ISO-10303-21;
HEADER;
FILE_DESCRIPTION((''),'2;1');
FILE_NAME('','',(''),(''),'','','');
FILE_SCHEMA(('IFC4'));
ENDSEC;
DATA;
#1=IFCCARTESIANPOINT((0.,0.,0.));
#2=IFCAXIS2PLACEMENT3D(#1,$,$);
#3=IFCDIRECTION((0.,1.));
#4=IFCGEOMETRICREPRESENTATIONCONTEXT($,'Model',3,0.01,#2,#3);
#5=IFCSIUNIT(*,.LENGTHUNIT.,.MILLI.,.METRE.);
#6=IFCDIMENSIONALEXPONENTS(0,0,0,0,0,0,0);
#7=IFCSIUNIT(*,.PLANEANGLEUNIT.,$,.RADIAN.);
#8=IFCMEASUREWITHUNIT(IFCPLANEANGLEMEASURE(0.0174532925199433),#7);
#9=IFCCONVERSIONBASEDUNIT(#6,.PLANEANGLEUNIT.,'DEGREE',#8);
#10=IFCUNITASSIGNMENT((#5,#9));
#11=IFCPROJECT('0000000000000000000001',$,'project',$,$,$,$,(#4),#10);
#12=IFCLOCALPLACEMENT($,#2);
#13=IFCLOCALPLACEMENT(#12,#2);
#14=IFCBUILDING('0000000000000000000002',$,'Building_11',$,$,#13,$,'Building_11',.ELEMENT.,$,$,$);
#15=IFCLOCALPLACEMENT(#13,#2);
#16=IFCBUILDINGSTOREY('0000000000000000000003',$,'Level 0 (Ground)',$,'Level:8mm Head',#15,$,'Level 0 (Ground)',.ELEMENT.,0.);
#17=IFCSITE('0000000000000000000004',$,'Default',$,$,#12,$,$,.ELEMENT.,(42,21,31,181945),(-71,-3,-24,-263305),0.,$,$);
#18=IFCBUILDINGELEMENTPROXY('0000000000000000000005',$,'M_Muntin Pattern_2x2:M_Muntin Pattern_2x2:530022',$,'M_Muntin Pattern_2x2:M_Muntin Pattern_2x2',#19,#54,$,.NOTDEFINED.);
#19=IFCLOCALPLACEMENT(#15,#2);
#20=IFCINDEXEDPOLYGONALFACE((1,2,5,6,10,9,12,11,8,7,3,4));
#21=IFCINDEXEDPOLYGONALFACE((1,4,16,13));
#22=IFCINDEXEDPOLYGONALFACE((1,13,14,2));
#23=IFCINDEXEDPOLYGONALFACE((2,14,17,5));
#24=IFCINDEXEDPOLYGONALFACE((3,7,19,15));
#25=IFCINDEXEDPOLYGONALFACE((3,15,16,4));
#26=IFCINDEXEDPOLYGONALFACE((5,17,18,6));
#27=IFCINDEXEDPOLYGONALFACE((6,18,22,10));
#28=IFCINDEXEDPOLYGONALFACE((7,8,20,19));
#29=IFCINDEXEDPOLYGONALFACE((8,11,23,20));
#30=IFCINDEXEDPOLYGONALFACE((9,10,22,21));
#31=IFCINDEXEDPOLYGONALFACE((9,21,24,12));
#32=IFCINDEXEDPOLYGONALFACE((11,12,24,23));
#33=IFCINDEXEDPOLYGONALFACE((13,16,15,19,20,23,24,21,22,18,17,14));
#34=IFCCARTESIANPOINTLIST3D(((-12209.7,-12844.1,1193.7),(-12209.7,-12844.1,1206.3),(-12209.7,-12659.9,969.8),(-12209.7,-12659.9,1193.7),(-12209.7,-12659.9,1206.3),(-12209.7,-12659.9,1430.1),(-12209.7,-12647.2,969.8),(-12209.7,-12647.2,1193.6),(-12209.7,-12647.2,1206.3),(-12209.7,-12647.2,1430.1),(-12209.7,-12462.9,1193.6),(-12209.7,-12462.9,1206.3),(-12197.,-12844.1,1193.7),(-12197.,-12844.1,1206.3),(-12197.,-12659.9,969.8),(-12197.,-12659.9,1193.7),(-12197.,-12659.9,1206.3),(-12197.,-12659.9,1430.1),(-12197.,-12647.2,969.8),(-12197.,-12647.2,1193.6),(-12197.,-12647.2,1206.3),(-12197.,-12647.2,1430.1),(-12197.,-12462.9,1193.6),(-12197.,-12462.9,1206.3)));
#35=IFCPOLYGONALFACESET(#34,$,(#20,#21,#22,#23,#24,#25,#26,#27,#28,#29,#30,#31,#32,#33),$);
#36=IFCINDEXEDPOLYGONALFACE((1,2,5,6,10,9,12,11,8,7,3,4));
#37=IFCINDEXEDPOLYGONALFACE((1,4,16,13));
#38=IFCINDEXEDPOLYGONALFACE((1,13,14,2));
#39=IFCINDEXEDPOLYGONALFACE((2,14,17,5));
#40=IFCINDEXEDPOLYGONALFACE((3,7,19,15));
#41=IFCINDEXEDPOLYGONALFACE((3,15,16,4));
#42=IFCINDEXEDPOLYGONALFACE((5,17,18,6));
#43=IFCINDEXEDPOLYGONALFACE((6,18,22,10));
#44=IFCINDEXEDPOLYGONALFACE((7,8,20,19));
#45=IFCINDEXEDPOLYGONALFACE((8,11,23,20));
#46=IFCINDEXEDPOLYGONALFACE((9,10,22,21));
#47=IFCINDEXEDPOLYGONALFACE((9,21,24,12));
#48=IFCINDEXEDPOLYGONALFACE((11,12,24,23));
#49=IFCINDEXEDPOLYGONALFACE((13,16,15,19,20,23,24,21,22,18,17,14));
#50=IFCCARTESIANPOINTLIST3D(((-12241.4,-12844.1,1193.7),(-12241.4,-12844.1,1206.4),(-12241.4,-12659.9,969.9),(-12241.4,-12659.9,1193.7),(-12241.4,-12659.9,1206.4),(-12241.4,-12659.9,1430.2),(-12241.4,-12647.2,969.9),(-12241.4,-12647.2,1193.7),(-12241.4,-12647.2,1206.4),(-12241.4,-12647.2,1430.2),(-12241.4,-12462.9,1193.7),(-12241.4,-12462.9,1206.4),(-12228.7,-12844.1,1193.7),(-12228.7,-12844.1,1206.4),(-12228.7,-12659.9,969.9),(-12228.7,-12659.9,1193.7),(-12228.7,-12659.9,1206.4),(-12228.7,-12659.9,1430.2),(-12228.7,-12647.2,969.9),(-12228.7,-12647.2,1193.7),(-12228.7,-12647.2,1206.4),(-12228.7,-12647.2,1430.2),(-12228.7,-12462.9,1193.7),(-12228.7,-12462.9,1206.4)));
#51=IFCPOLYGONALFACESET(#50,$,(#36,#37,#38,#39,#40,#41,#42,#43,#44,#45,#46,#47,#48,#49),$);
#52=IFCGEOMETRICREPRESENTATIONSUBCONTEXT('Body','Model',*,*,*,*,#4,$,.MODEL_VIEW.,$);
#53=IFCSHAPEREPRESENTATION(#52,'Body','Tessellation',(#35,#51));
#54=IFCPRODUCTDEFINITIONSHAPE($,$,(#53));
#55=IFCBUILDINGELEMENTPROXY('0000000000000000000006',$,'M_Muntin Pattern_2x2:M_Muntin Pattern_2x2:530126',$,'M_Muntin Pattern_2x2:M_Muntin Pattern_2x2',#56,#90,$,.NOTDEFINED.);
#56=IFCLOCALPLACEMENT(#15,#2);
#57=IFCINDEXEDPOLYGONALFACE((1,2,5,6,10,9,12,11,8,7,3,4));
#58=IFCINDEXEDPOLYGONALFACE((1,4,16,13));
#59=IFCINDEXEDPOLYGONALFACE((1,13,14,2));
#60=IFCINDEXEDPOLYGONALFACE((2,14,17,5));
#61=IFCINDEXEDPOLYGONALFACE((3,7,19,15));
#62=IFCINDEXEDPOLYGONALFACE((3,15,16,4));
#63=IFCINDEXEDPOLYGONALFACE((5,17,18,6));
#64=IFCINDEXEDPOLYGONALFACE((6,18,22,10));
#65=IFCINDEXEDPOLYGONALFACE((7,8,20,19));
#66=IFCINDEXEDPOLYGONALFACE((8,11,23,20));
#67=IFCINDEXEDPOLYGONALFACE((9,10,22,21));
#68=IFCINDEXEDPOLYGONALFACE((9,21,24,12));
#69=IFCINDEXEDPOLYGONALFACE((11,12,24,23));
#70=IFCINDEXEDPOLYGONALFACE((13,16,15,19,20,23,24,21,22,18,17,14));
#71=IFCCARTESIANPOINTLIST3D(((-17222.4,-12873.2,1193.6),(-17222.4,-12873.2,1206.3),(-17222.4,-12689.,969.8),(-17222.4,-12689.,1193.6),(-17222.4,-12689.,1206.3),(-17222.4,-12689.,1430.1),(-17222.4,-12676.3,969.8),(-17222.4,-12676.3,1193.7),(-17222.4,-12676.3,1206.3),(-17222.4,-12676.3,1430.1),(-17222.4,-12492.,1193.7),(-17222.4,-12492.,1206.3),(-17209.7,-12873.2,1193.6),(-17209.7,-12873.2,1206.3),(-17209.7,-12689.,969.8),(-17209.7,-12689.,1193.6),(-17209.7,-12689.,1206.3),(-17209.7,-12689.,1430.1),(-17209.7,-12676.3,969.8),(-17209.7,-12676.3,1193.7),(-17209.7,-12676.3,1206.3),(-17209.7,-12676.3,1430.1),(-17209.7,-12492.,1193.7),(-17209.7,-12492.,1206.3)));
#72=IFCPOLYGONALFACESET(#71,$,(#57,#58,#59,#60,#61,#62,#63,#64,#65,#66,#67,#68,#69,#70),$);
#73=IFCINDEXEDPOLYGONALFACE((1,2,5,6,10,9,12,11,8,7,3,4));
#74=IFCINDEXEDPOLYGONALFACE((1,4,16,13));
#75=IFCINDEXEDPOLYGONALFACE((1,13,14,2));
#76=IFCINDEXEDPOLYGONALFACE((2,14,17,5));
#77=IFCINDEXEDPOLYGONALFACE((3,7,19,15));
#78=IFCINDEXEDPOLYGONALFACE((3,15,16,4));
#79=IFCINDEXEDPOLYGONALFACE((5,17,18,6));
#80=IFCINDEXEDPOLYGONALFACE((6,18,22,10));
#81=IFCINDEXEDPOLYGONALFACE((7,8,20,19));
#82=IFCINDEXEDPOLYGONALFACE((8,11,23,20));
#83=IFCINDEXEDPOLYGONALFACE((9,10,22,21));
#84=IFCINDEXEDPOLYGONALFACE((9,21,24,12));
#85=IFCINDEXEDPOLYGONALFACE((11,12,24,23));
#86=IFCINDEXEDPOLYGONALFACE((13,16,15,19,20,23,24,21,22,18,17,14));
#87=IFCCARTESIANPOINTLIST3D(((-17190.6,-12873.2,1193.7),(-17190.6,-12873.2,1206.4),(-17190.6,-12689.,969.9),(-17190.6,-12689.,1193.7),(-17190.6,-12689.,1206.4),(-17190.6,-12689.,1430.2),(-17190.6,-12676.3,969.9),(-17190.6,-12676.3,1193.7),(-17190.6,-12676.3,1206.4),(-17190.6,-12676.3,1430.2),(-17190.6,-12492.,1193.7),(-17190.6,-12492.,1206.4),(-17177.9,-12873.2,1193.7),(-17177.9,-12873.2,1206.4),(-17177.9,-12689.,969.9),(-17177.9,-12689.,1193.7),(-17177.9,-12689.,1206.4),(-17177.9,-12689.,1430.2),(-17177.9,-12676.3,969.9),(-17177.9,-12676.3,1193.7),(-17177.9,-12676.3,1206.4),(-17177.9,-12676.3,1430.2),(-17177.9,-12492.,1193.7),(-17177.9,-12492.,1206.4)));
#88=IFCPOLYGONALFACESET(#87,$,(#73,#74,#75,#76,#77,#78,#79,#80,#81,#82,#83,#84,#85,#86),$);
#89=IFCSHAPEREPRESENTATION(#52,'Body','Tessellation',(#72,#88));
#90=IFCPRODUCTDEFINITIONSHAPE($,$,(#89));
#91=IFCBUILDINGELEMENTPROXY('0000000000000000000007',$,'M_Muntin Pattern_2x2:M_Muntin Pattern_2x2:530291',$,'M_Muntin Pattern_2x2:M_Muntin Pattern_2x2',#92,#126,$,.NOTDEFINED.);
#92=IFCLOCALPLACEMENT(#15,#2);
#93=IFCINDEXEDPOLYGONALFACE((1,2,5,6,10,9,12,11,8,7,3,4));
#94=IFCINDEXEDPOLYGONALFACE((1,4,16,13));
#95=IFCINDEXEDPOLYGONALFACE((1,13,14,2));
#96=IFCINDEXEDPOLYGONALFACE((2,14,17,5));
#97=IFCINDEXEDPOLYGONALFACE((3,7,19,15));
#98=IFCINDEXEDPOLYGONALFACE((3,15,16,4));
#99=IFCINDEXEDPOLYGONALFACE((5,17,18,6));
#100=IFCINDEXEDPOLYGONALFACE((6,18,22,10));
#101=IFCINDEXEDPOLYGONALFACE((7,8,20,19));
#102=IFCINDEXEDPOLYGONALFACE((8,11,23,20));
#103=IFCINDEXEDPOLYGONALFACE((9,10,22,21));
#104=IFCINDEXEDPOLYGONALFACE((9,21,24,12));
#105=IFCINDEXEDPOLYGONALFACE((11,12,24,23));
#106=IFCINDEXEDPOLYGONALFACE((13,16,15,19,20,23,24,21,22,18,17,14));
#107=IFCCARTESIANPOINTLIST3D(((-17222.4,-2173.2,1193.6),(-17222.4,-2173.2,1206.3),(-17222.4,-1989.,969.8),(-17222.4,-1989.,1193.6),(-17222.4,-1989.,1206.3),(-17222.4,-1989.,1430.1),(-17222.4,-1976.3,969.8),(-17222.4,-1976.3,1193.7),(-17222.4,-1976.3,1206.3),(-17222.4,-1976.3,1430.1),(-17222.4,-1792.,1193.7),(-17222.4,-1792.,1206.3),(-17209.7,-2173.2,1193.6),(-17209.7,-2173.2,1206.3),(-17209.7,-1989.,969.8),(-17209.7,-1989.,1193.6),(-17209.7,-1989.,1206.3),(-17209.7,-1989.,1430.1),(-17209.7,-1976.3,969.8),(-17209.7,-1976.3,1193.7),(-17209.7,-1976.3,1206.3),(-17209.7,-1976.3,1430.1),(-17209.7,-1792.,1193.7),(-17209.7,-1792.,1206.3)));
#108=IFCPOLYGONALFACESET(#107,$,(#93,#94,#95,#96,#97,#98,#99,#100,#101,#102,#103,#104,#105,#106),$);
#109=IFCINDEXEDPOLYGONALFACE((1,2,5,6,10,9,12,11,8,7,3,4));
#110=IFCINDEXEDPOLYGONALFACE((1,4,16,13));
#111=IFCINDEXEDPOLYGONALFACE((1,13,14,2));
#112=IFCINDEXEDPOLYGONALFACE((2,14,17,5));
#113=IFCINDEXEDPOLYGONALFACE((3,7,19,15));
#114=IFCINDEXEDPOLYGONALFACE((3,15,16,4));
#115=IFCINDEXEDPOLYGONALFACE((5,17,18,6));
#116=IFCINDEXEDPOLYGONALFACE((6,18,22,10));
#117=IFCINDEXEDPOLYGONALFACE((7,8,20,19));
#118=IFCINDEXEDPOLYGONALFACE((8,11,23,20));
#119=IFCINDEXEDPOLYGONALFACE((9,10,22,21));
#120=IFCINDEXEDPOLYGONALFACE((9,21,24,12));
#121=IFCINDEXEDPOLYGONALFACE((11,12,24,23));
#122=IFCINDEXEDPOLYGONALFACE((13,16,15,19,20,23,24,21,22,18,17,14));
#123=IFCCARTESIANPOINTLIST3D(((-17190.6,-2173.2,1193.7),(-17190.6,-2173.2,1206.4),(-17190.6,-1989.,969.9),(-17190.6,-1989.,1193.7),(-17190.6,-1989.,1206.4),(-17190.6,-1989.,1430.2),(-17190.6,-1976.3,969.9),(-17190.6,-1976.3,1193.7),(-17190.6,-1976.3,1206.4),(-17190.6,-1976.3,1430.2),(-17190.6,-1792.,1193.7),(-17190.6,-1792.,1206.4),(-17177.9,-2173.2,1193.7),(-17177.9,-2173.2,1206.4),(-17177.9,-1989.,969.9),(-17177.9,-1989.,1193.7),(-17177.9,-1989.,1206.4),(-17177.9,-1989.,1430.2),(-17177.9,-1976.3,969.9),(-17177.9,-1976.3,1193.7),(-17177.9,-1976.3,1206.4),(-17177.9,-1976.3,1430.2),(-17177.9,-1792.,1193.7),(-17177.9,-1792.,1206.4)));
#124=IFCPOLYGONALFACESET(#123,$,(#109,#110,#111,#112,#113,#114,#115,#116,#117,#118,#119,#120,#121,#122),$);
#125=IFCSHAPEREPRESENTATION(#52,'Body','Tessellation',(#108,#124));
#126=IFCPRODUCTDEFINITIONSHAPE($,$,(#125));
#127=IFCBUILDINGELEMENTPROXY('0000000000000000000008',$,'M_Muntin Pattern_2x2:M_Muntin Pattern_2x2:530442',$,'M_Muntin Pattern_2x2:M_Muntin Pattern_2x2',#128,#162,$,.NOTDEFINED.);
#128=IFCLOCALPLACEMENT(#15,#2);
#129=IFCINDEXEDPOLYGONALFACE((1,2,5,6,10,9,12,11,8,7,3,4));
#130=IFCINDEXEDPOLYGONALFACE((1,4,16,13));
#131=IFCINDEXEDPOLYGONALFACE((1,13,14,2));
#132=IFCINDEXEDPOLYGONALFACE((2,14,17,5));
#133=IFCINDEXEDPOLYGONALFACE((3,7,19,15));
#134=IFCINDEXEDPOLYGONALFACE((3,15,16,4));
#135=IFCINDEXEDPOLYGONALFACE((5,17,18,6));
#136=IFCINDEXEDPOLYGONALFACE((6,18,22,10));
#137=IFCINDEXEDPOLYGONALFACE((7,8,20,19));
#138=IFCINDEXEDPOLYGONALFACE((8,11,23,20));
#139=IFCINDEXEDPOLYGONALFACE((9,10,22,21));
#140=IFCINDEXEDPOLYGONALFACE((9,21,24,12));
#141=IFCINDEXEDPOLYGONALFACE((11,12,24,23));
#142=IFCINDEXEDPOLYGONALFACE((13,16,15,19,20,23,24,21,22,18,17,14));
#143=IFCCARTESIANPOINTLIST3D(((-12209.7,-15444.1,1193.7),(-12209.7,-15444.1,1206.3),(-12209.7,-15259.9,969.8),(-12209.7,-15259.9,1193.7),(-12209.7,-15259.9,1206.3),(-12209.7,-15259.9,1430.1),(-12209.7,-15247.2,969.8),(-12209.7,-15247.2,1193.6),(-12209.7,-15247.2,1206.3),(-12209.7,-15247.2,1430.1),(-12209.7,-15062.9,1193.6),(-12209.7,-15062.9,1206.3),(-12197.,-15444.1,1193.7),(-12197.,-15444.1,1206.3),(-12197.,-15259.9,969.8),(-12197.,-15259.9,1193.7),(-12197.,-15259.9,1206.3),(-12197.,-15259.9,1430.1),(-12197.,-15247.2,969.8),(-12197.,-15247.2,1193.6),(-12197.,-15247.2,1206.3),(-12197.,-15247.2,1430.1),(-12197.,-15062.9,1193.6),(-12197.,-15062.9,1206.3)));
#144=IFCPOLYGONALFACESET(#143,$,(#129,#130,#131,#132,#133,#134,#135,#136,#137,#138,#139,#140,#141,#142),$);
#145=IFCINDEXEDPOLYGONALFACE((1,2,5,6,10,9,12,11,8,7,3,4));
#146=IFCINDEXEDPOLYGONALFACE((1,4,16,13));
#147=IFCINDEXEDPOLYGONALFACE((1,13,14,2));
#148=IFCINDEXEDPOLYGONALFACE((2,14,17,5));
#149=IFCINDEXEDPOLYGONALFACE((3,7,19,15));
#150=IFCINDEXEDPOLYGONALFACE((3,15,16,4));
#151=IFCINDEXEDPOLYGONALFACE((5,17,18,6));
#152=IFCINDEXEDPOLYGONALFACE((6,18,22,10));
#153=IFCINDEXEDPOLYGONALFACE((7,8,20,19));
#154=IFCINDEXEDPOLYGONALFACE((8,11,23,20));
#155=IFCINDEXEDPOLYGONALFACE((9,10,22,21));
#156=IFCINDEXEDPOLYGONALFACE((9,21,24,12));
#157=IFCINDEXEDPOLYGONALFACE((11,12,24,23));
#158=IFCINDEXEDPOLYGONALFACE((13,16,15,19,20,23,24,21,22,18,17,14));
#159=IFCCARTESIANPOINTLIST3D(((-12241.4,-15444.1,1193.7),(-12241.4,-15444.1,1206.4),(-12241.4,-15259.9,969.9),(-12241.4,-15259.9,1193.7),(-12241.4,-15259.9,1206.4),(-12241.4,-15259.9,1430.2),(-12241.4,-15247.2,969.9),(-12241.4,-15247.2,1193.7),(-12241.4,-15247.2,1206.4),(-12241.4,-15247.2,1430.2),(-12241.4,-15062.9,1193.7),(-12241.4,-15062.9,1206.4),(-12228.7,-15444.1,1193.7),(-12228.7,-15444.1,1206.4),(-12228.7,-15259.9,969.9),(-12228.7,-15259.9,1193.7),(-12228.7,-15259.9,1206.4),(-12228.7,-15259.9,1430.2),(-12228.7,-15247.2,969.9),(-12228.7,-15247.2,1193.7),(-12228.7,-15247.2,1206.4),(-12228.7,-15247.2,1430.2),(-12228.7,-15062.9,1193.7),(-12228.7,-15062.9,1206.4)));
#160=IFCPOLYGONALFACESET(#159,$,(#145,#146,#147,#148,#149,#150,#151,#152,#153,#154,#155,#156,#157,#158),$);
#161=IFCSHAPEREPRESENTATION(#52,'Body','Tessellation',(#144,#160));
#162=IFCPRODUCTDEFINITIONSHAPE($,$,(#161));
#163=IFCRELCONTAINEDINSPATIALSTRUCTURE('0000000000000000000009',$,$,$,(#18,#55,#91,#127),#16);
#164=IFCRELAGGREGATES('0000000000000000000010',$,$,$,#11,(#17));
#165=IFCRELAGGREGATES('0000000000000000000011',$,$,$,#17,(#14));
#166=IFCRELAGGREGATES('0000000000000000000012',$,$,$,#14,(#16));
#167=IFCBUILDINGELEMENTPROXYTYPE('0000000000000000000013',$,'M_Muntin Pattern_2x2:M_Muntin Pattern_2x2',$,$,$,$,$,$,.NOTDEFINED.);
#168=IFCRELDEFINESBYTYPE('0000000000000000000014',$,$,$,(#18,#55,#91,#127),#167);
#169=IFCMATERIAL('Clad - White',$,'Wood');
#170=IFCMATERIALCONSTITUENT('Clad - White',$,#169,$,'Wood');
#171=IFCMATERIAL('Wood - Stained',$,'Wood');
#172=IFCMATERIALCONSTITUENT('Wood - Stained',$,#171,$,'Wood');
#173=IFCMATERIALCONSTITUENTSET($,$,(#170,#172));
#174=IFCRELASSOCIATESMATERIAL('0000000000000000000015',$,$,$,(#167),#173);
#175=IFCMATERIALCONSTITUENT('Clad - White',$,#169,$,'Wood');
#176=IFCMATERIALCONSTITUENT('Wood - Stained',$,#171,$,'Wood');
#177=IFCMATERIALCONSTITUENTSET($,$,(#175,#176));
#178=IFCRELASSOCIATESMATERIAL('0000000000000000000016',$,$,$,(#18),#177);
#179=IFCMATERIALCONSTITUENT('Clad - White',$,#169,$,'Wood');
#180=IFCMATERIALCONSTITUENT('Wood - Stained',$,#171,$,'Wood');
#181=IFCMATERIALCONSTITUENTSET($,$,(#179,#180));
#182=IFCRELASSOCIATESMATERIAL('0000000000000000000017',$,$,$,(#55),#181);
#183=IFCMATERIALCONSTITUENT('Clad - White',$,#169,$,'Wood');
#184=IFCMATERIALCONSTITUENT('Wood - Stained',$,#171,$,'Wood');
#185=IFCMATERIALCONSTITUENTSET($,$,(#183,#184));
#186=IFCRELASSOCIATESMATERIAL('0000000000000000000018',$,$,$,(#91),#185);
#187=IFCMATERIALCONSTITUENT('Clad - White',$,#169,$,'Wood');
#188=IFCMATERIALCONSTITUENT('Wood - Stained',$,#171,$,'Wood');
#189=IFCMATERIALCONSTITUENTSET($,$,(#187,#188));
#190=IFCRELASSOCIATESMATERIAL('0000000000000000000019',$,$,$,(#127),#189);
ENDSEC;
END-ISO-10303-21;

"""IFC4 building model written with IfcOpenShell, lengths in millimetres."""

from ifc_helpers import new_model, entity, si_unit, converted_unit, direction, frame, origin, place, context, subcontext, project, spatial, indexed_curve, outline, extrude, source, transform, mapped, material, constituent, constituent_set, type_object, type_shapes, element, save


model = new_model("IFC4")

# Units and contexts
model_context = context("Model", 3, precision=0.01, world=origin(), true_north=direction((0.0, 1.0)))
body_context = subcontext(model_context, "Body", "Model", "MODEL_VIEW")
ifc_project = project(units=[si_unit("LENGTHUNIT", "METRE", prefix="MILLI"), converted_unit("PLANEANGLEUNIT", "DEGREE", entity("IfcPlaneAngleMeasure", 0.0174532925199433), si_unit("PLANEANGLEUNIT", "RADIAN"), dimensions=[0, 0, 0, 0, 0, 0, 0])], contexts=[model_context])

# Site, building, storey
site_placement = place(None, origin())
site = spatial("IfcSite", under=ifc_project, at=site_placement, Name="Default", CompositionType="ELEMENT", RefLatitude=(42, 21, 31, 181945), RefLongitude=(-71, -3, -24, -263305), RefElevation=0.0)
building_placement = place(site_placement, origin())
building = spatial("IfcBuilding", under=site, at=building_placement, Name="Building_11", LongName="Building_11", CompositionType="ELEMENT")
storey_placement = place(building_placement, origin())
storey = spatial("IfcBuildingStorey", under=building, at=storey_placement, Name="Level 0 (Ground)", ObjectType="Level:8mm Head", LongName="Level 0 (Ground)", CompositionType="ELEMENT", Elevation=0.0)

# Building element proxies
ifc_material_1 = material(Name="Clad - White", Category="Wood")
ifc_constituent_1 = constituent(ifc_material_1, Name="Clad - White", Category="Wood")
ifc_material_2 = material(Name="Wood - Stained", Category="Wood")
ifc_constituent_2 = constituent(ifc_material_2, Name="Wood - Stained", Category="Wood")
ifc_constituent_set_1 = constituent_set(constituents=[ifc_constituent_1, ifc_constituent_2])
ifc_constituent_3 = constituent(ifc_material_1, Name="Clad - White", Category="Wood")
ifc_constituent_4 = constituent(ifc_material_2, Name="Wood - Stained", Category="Wood")
ifc_constituent_set_2 = constituent_set(constituents=[ifc_constituent_3, ifc_constituent_4])
building_element_proxy_type_1 = type_object("IfcBuildingElementProxyType", Name="M_Muntin Pattern_2x2:M_Muntin Pattern_2x2", PredefinedType="NOTDEFINED", material=ifc_constituent_set_2)
shared_shape_1 = source(origin(), body_context, "Body", "SweptSolid", [
    extrude(outline(indexed_curve([(6.4, -6.4), (230.1, -6.4), (230.1, 6.3), (6.4, 6.3), (6.4, 190.6), (-6.3, 190.6), (-6.3, 6.3), (-230.2, 6.3), (-230.2, -6.4), (-6.3, -6.4), (-6.3, -190.6), (6.4, -190.6), (6.4, -6.4)], self_intersect=False)), frame((0.0, 9.5, 230.1), z_axis=(0.0, 1.0, 0.0), x_axis=(0.0, 0.0, 1.0)), (0.0, 0.0, 1.0), 12.7),
    extrude(outline(indexed_curve([(6.4, -6.4), (230.2, -6.4), (230.2, 6.3), (6.4, 6.3), (6.4, 190.6), (-6.3, 190.6), (-6.3, 6.3), (-230.2, 6.3), (-230.2, -6.4), (-6.3, -6.4), (-6.3, -190.6), (6.4, -190.6), (6.4, -6.4)], self_intersect=False)), frame((0.0, -22.2, 230.2), z_axis=(0.0, 1.0, 0.0), x_axis=(0.0, 0.0, 1.0)), (0.0, 0.0, 1.0), 12.7),
])
type_shapes(building_element_proxy_type_1, [shared_shape_1])
proxy_1_placement = place(storey_placement, frame((-12219.2, -12653.5, 969.9), z_axis=(0.0, 0.0, 1.0), x_axis=(0.0, -1.0, 0.0)))
element("IfcBuildingElementProxy", 1, at=proxy_1_placement, inside=storey, type_object=building_element_proxy_type_1, material=ifc_constituent_set_1, Name="M_Muntin Pattern_2x2:M_Muntin Pattern_2x2:530022", ObjectType="M_Muntin Pattern_2x2:M_Muntin Pattern_2x2", PredefinedType="NOTDEFINED", context=body_context, shape_type="MappedRepresentation", body=[
    mapped(shared_shape_1, transform((0.0, 0.0, 0.0), scale=1.0)),
])
ifc_constituent_5 = constituent(ifc_material_1, Name="Clad - White", Category="Wood")
ifc_constituent_6 = constituent(ifc_material_2, Name="Wood - Stained", Category="Wood")
ifc_constituent_set_3 = constituent_set(constituents=[ifc_constituent_5, ifc_constituent_6])
proxy_2_placement = place(storey_placement, frame((-17200.2, -12682.6, 969.9), z_axis=(0.0, 0.0, 1.0), x_axis=(0.0, 1.0, 0.0)))
element("IfcBuildingElementProxy", 2, at=proxy_2_placement, inside=storey, type_object=building_element_proxy_type_1, material=ifc_constituent_set_3, Name="M_Muntin Pattern_2x2:M_Muntin Pattern_2x2:530126", ObjectType="M_Muntin Pattern_2x2:M_Muntin Pattern_2x2", PredefinedType="NOTDEFINED", context=body_context, shape_type="MappedRepresentation", body=[
    mapped(shared_shape_1, transform((0.0, 0.0, 0.0), scale=1.0)),
])
ifc_constituent_7 = constituent(ifc_material_1, Name="Clad - White", Category="Wood")
ifc_constituent_8 = constituent(ifc_material_2, Name="Wood - Stained", Category="Wood")
ifc_constituent_set_4 = constituent_set(constituents=[ifc_constituent_7, ifc_constituent_8])
proxy_3_placement = place(storey_placement, frame((-17200.2, -1982.6, 969.9), z_axis=(0.0, 0.0, 1.0), x_axis=(0.0, 1.0, 0.0)))
element("IfcBuildingElementProxy", 3, at=proxy_3_placement, inside=storey, type_object=building_element_proxy_type_1, material=ifc_constituent_set_4, Name="M_Muntin Pattern_2x2:M_Muntin Pattern_2x2:530291", ObjectType="M_Muntin Pattern_2x2:M_Muntin Pattern_2x2", PredefinedType="NOTDEFINED", context=body_context, shape_type="MappedRepresentation", body=[
    mapped(shared_shape_1, transform((0.0, 0.0, 0.0), scale=1.0)),
])
ifc_constituent_9 = constituent(ifc_material_1, Name="Clad - White", Category="Wood")
ifc_constituent_10 = constituent(ifc_material_2, Name="Wood - Stained", Category="Wood")
ifc_constituent_set_5 = constituent_set(constituents=[ifc_constituent_9, ifc_constituent_10])
proxy_4_placement = place(storey_placement, frame((-12219.2, -15253.5, 969.9), z_axis=(0.0, 0.0, 1.0), x_axis=(0.0, -1.0, 0.0)))
element("IfcBuildingElementProxy", 4, at=proxy_4_placement, inside=storey, type_object=building_element_proxy_type_1, material=ifc_constituent_set_5, Name="M_Muntin Pattern_2x2:M_Muntin Pattern_2x2:530442", ObjectType="M_Muntin Pattern_2x2:M_Muntin Pattern_2x2", PredefinedType="NOTDEFINED", context=body_context, shape_type="MappedRepresentation", body=[
    mapped(shared_shape_1, transform((0.0, 0.0, 0.0), scale=1.0)),
])

save(model, "model.ifc")
